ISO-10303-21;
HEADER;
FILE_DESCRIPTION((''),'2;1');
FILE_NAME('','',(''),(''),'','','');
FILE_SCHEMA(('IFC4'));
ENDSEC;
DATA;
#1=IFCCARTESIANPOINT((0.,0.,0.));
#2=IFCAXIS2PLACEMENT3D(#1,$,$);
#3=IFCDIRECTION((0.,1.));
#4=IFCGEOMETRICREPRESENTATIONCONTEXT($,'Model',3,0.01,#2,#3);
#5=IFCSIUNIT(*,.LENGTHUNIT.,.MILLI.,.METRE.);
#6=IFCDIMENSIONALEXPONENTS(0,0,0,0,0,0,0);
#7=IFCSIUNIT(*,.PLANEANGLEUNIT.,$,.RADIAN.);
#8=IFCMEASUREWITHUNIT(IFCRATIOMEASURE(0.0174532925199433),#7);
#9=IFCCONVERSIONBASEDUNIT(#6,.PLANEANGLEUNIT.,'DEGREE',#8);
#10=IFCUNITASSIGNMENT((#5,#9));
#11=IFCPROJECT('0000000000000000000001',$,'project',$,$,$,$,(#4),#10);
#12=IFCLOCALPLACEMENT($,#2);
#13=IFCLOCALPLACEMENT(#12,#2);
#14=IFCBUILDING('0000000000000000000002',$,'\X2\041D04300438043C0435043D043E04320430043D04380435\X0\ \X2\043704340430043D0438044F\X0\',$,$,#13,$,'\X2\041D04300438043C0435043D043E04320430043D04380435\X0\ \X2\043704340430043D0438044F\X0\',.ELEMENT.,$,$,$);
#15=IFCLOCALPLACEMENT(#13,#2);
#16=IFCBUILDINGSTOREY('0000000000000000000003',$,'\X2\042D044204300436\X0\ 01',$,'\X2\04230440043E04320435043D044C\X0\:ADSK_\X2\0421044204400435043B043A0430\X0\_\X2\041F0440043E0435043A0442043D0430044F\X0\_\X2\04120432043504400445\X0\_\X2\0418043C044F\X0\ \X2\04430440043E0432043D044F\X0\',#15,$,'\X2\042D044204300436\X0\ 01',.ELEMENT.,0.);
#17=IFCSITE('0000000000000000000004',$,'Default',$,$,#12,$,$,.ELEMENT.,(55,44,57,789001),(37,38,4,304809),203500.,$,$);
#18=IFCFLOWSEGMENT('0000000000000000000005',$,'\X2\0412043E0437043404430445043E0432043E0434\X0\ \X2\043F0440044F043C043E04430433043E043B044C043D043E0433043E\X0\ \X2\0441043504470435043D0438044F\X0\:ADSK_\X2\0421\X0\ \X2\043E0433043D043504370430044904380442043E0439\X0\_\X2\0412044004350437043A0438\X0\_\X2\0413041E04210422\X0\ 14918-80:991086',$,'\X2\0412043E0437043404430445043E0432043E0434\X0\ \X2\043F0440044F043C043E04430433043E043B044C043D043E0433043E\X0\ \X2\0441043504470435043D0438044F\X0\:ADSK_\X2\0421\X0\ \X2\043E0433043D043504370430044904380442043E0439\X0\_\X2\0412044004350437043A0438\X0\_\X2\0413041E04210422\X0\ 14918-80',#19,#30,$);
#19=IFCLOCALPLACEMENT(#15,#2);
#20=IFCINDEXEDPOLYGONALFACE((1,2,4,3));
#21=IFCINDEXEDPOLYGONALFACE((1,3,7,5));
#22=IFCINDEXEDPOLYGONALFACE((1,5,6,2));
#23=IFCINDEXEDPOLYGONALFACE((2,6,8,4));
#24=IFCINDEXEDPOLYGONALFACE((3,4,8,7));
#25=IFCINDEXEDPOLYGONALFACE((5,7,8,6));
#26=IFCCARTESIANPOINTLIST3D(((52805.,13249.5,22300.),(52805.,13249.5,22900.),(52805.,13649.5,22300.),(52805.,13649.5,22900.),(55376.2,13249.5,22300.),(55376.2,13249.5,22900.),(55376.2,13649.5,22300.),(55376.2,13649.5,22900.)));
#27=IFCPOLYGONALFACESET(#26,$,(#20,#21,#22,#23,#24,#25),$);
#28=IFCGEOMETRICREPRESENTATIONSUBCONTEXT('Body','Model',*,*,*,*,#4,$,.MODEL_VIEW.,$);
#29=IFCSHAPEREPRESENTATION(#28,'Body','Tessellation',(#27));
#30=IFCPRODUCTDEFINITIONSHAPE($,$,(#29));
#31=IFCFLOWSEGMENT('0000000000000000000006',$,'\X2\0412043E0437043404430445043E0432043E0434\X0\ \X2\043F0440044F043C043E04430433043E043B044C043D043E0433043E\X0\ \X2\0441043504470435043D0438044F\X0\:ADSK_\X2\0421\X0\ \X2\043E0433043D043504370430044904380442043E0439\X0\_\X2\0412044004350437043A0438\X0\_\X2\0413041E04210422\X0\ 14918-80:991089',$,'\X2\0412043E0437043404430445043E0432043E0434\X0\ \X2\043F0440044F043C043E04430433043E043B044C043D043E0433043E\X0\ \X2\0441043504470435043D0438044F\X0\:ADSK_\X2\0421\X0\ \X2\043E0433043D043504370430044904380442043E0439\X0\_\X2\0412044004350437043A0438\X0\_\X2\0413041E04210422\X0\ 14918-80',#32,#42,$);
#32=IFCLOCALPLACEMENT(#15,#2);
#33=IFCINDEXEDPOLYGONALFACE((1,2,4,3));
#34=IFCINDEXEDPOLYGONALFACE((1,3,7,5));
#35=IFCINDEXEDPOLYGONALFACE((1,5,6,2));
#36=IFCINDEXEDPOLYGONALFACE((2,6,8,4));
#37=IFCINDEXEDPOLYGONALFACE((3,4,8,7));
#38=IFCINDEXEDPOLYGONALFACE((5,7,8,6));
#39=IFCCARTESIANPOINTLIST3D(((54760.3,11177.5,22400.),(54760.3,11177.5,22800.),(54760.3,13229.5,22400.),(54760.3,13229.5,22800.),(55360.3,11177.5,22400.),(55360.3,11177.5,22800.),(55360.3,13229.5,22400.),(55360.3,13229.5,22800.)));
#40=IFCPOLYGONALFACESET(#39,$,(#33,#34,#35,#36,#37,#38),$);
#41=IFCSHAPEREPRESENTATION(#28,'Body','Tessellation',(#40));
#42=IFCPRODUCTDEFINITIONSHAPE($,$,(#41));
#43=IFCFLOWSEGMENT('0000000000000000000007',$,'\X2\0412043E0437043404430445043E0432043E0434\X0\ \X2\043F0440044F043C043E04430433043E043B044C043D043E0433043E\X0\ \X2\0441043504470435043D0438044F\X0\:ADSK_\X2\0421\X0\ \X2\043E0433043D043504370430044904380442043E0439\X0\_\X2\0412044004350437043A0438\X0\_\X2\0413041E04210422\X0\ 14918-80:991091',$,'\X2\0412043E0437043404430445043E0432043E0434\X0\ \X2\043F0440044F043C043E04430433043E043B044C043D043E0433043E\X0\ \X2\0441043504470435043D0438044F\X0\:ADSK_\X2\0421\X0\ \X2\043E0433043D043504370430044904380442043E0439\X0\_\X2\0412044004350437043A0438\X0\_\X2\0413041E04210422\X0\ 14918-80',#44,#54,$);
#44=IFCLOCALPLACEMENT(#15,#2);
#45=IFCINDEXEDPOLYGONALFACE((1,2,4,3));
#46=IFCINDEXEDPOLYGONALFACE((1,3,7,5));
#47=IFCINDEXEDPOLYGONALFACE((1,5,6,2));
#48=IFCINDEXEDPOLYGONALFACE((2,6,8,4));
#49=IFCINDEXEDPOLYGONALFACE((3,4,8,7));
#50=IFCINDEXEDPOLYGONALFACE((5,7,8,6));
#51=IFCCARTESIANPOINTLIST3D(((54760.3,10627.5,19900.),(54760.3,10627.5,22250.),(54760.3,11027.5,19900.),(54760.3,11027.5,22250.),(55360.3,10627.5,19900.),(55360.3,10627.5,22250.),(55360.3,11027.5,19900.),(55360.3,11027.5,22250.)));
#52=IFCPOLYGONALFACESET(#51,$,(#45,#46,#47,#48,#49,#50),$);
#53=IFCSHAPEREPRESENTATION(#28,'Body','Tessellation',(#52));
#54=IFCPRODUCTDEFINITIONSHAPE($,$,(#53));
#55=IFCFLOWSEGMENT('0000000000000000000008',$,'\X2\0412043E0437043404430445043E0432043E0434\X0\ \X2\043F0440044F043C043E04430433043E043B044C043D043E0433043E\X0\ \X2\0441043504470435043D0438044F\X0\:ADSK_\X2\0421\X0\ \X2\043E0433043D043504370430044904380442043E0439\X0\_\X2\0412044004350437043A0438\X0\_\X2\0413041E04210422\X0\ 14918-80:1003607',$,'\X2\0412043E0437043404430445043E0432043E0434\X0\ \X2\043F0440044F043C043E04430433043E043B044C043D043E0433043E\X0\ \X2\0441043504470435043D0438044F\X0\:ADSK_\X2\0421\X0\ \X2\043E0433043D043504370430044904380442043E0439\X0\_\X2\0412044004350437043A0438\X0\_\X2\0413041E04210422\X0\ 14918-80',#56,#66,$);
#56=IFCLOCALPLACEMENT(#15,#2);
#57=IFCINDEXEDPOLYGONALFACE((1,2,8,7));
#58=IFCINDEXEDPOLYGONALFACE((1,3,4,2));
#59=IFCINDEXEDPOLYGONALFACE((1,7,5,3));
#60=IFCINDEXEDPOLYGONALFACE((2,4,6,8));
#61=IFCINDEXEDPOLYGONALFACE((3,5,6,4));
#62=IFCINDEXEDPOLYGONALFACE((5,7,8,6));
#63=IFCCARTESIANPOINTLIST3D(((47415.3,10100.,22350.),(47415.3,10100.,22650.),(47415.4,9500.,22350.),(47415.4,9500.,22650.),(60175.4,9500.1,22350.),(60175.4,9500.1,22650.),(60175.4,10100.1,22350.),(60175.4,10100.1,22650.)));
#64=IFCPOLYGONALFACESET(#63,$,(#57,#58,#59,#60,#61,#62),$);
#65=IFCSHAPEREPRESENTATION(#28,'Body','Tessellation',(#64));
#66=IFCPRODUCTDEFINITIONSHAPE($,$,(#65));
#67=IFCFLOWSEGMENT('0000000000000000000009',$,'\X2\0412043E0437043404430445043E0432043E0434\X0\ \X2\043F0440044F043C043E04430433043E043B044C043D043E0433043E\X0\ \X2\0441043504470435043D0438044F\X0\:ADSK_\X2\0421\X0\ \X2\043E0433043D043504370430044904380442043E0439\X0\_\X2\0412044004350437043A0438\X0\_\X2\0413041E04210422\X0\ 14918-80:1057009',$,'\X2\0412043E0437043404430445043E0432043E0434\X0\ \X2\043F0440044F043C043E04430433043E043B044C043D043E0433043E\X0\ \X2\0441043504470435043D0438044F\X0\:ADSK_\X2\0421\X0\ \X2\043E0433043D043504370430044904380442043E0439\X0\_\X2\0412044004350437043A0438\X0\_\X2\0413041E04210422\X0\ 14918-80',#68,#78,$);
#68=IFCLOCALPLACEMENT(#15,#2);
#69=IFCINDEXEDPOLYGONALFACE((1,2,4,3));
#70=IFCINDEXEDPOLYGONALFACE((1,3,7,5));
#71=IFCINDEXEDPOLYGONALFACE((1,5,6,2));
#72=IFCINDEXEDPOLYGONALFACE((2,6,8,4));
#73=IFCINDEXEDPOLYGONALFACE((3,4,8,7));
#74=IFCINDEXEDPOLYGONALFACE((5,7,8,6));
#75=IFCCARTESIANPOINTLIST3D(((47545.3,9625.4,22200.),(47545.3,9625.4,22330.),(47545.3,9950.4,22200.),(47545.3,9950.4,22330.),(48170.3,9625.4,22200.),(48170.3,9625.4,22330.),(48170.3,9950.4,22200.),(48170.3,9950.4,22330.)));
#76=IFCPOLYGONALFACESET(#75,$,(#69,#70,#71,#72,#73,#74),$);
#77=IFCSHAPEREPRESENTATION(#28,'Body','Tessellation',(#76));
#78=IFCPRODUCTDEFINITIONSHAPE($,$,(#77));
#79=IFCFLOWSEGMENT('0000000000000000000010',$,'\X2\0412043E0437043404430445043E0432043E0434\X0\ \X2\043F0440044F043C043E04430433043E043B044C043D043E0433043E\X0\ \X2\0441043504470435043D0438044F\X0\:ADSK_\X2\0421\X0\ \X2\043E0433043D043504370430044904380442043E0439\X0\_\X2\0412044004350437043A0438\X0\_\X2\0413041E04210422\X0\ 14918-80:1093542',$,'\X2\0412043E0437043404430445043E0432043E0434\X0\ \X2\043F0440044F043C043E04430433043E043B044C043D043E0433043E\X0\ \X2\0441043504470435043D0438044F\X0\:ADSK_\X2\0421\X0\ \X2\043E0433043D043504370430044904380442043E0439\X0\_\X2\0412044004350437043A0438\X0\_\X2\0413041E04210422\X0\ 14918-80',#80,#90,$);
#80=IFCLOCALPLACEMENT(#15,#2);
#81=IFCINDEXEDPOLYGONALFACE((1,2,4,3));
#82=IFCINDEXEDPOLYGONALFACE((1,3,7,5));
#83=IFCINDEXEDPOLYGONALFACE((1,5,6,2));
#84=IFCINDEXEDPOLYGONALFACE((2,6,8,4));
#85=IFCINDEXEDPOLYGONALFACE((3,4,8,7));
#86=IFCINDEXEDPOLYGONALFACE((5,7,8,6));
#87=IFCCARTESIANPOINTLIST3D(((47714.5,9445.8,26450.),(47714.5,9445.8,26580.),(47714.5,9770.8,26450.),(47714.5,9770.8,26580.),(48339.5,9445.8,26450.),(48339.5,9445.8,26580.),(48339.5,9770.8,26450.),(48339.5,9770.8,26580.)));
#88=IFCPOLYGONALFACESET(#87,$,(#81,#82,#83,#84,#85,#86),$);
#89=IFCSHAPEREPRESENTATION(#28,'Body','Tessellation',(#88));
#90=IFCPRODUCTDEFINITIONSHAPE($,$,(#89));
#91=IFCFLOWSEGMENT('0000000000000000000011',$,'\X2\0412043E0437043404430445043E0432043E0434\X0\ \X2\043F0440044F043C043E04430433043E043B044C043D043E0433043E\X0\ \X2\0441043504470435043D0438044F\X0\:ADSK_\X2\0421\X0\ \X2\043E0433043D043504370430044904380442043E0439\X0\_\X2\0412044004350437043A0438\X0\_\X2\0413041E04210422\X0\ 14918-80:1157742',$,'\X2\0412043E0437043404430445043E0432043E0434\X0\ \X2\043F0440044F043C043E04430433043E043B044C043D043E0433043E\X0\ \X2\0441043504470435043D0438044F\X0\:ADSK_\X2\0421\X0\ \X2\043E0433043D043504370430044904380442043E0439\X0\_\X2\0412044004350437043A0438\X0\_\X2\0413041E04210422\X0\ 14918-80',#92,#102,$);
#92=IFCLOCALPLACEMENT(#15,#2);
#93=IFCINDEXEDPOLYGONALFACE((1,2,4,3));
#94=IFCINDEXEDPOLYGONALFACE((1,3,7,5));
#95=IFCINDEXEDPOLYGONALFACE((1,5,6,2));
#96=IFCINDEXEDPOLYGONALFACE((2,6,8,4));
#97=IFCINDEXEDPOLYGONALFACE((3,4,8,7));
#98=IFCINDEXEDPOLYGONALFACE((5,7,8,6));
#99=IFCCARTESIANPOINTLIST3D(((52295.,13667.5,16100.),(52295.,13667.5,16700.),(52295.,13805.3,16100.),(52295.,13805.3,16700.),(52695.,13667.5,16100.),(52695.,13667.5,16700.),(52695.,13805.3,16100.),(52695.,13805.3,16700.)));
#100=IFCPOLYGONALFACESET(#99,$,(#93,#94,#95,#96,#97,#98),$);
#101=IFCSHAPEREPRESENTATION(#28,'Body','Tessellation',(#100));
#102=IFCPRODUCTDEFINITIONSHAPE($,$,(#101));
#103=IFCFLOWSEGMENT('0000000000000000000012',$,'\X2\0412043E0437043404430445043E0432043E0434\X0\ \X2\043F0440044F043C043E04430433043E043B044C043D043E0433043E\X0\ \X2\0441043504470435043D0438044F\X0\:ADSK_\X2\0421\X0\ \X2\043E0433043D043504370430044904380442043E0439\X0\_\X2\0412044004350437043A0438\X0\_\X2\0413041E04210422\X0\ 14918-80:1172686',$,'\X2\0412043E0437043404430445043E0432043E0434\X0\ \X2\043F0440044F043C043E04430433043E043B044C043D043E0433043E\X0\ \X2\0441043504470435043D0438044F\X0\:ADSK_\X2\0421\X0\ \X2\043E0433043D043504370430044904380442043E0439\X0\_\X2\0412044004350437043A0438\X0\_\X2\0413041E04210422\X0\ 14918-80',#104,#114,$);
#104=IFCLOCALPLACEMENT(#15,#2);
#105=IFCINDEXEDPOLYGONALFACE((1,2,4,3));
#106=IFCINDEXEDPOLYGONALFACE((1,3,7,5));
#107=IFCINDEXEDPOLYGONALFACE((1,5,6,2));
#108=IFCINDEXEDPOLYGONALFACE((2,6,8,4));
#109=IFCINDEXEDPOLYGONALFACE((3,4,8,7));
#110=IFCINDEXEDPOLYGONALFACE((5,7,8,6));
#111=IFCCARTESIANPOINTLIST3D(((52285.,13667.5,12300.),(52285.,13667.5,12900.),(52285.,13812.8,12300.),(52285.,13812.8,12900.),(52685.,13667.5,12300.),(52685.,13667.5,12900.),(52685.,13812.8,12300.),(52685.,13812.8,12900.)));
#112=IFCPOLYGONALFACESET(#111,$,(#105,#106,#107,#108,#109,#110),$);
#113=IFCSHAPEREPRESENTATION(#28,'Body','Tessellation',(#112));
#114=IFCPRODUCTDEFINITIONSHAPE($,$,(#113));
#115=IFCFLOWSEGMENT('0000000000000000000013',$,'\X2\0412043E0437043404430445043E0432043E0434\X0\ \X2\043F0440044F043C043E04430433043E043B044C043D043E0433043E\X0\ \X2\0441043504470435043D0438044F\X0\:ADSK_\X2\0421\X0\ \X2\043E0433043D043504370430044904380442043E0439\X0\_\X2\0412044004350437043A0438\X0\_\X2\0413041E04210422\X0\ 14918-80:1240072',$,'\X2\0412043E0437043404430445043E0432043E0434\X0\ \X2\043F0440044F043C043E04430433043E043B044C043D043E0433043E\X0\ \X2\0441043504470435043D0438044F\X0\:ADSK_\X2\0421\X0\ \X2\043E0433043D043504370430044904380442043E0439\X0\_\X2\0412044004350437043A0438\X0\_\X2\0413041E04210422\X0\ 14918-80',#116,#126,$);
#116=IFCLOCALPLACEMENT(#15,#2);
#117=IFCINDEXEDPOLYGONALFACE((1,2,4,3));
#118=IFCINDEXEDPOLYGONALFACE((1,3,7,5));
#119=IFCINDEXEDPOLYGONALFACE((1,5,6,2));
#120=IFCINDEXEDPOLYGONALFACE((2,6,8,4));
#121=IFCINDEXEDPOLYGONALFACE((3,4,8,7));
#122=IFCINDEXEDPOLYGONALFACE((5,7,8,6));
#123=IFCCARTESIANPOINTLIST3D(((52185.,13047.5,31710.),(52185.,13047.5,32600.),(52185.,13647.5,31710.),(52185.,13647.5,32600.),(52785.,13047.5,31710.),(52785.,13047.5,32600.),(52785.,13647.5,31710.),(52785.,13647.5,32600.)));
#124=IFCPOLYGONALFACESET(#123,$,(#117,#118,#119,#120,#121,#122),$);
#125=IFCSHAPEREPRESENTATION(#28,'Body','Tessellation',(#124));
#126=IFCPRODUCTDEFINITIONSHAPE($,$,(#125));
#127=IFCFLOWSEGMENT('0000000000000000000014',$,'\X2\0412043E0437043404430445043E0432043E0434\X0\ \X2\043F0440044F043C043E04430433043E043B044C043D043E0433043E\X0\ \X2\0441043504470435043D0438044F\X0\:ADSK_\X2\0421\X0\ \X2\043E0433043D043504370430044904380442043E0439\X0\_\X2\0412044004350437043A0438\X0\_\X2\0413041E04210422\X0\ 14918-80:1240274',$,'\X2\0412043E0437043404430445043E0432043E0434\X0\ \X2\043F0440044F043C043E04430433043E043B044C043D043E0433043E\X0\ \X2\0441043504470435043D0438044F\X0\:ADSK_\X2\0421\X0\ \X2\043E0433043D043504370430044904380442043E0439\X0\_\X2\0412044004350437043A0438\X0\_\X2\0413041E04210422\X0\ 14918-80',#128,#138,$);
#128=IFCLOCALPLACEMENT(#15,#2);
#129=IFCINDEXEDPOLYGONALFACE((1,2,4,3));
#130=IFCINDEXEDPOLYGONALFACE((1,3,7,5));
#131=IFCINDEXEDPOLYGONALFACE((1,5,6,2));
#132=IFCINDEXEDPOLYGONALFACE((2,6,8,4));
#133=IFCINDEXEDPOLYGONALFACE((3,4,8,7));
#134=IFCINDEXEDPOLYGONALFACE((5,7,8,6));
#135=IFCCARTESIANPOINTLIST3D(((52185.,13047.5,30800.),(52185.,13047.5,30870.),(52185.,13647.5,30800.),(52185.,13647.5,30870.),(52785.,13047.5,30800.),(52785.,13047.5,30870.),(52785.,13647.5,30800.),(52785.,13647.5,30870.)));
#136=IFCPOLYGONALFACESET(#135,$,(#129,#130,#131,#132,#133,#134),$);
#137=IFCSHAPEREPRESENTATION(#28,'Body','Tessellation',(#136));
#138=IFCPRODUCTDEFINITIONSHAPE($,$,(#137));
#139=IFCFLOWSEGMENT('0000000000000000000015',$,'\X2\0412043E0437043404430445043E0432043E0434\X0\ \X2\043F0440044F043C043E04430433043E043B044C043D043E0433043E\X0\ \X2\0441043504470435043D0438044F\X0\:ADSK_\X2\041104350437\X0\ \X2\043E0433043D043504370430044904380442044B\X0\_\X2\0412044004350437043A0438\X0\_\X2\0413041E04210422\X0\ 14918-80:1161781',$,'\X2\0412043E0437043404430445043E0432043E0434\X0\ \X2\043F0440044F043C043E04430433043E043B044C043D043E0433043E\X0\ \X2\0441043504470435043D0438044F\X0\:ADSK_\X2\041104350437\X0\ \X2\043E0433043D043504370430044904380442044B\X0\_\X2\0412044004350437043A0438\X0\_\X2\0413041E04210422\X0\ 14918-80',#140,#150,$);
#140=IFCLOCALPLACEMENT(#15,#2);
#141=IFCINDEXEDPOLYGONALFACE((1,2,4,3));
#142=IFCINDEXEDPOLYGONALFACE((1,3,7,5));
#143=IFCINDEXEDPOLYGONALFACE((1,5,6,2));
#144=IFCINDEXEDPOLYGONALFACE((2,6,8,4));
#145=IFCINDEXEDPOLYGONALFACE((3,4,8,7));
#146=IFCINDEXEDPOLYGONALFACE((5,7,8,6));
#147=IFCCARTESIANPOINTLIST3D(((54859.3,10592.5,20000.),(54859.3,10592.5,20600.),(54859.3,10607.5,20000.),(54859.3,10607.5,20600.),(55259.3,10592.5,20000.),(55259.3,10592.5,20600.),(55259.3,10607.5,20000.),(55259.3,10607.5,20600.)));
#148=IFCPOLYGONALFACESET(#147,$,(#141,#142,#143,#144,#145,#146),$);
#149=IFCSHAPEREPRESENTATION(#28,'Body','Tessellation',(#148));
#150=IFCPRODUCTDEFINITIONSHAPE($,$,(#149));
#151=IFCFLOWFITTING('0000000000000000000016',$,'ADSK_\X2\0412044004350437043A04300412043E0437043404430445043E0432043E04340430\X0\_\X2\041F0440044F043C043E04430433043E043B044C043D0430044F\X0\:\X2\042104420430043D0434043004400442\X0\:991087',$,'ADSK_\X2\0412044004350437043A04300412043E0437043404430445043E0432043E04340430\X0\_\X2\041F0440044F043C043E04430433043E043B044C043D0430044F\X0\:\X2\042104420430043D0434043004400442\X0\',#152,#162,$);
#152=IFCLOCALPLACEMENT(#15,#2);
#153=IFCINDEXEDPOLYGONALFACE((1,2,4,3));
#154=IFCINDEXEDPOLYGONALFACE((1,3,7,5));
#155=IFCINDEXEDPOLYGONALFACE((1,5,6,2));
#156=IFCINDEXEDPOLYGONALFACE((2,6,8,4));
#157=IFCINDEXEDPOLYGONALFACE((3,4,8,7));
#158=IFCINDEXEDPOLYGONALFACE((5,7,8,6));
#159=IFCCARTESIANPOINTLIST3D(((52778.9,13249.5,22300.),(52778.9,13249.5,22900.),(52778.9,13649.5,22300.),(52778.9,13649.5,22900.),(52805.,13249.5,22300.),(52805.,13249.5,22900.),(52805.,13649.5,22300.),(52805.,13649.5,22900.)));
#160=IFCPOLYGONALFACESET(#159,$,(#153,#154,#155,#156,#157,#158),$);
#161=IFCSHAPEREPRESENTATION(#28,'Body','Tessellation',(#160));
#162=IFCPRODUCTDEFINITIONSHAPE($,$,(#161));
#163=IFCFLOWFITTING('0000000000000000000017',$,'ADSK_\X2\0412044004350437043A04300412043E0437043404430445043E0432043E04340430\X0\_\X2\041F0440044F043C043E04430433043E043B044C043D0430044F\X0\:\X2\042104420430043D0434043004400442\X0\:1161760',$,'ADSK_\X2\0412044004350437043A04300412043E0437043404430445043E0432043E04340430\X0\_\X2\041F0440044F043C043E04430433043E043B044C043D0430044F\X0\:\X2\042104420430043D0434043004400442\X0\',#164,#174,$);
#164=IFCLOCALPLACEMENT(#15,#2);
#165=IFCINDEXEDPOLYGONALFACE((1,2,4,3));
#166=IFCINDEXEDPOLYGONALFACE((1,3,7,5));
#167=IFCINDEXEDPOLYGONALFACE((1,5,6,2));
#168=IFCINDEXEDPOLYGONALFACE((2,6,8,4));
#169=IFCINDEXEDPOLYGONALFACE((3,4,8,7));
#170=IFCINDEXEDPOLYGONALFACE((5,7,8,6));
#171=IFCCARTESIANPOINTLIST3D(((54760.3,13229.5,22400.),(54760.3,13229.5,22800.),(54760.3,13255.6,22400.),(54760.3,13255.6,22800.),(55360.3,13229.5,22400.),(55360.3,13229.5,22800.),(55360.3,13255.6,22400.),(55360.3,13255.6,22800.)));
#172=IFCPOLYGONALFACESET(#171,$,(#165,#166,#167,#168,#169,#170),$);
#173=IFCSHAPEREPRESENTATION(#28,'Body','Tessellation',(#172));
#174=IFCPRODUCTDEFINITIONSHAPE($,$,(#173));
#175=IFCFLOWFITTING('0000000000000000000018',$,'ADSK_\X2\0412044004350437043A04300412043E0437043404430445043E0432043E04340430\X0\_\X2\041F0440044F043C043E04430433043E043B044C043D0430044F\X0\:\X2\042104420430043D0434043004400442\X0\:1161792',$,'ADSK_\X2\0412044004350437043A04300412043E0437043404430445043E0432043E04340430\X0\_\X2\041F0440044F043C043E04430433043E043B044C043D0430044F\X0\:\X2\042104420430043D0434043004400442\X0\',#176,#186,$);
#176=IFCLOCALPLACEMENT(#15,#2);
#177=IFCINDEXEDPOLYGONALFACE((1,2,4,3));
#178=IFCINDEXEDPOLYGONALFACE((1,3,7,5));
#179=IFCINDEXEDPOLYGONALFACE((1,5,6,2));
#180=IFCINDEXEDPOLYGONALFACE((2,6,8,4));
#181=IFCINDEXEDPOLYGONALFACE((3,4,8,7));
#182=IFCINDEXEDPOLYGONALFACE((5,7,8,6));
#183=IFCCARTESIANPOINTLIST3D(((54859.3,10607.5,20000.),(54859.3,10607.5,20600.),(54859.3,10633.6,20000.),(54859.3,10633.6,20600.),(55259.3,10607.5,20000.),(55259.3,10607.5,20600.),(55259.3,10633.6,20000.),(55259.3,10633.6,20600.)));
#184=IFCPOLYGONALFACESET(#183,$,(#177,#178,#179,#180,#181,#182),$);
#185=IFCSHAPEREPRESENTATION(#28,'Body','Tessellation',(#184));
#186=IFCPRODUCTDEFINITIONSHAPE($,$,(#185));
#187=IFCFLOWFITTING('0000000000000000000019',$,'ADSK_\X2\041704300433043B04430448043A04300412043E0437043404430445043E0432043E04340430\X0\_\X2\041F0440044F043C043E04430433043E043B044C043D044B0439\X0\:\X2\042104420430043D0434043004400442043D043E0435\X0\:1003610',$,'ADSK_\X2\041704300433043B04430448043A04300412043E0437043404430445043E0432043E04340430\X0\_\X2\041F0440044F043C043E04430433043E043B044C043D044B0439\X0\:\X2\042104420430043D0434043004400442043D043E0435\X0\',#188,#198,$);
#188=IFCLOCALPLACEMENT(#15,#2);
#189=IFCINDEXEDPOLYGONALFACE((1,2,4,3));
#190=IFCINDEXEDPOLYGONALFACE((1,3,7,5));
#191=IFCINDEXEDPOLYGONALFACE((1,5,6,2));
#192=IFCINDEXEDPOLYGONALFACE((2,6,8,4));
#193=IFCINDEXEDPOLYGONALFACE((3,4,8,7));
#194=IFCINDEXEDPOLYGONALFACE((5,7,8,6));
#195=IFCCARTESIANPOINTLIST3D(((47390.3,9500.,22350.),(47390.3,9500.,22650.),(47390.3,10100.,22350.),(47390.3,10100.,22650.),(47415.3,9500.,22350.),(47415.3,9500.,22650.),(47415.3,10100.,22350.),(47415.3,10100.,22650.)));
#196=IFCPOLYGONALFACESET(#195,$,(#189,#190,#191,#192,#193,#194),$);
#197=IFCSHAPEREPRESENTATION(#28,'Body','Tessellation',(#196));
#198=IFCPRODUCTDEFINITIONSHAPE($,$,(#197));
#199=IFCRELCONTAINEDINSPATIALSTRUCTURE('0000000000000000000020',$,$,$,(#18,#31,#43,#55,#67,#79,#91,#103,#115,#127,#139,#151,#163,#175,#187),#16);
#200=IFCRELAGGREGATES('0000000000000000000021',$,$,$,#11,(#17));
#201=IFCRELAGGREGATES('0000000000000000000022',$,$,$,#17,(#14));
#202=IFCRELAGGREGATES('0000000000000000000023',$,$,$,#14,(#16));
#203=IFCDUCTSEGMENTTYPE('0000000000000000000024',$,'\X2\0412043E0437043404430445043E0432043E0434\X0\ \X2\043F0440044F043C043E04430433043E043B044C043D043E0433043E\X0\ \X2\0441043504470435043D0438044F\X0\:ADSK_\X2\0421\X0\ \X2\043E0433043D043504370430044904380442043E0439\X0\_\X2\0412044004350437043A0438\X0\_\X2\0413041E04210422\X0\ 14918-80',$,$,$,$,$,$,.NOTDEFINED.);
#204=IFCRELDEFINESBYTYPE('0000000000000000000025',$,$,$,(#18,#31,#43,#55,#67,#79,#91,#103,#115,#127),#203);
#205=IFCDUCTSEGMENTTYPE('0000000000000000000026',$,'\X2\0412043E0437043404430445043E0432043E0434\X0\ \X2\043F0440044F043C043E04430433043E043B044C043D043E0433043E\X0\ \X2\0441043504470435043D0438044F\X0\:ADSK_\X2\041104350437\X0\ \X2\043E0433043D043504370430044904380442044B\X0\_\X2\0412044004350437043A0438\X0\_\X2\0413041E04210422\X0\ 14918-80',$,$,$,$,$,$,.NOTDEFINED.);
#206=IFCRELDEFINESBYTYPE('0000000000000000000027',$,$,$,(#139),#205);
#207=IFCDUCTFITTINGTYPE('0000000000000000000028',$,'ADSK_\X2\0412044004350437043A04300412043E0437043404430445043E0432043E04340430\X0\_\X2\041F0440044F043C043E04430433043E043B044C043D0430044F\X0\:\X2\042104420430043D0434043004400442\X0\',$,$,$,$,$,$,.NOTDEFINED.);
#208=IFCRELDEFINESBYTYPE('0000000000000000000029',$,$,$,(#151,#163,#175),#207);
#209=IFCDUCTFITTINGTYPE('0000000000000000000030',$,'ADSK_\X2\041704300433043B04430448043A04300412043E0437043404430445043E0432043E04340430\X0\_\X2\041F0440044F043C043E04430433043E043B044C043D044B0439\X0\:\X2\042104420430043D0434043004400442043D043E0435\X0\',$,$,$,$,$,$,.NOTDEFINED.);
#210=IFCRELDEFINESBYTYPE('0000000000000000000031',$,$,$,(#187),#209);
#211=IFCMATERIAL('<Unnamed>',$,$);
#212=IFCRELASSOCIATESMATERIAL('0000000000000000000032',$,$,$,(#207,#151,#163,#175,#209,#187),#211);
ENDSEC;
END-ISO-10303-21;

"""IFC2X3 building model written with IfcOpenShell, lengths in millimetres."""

from ifc_helpers import new_model, entity, si_unit, converted_unit, direction, frame, origin, origin_2d_with_axis, place, context, subcontext, project, spatial, rectangle, extrude, source, transform, mapped, material, type_object, type_shapes, element, save


model = new_model("IFC2X3")

# Units and contexts
model_context = context("Model", 3, precision=0.01, world=origin(), true_north=direction((0.0, 1.0)))
body_context = subcontext(model_context, "Body", "Model", "MODEL_VIEW")
ifc_project = project(units=[si_unit("LENGTHUNIT", "METRE", prefix="MILLI"), converted_unit("PLANEANGLEUNIT", "DEGREE", entity("IfcRatioMeasure", 0.0174532925199433), si_unit("PLANEANGLEUNIT", "RADIAN"), dimensions=[0, 0, 0, 0, 0, 0, 0])], contexts=[model_context])

# Site, building, storey
site_placement = place(None, origin())
site = spatial("IfcSite", under=ifc_project, at=site_placement, Name="Default", CompositionType="ELEMENT", RefLatitude=(55, 44, 57, 789001), RefLongitude=(37, 38, 4, 304809), RefElevation=203500.0)
building_placement = place(site_placement, origin())
building = spatial("IfcBuilding", under=site, at=building_placement, Name="Наименование здания", LongName="Наименование здания", CompositionType="ELEMENT")
storey_placement = place(building_placement, origin())
storey = spatial("IfcBuildingStorey", under=building, at=storey_placement, Name="Этаж 01", ObjectType="Уровень:ADSK_Стрелка_Проектная_Вверх_Имя уровня", LongName="Этаж 01", CompositionType="ELEMENT", Elevation=0.0)

# Flow segments
duct_segment_type_1 = type_object("IfcDuctSegmentType", Name="Воздуховод прямоугольного сечения:ADSK_С огнезащитой_Врезки_ГОСТ 14918-80", PredefinedType="NOTDEFINED")
flow_segment_1_placement = place(storey_placement, frame((52805.0, 13249.5, 22300.0)))
element("IfcFlowSegment", 1, at=flow_segment_1_placement, inside=storey, type_object=duct_segment_type_1, Name="Воздуховод прямоугольного сечения:ADSK_С огнезащитой_Врезки_ГОСТ 14918-80:991086", ObjectType="Воздуховод прямоугольного сечения:ADSK_С огнезащитой_Врезки_ГОСТ 14918-80", context=body_context, shape_type="SweptSolid", body=[
    extrude(rectangle(XDim=2571.2, YDim=400.0, at=origin_2d_with_axis()), frame((1285.6, 200.0, 0.0)), (0.0, 0.0, 1.0), 600.0),
])
flow_segment_2_placement = place(storey_placement, frame((54760.3, 11177.5, 22400.0)))
element("IfcFlowSegment", 2, at=flow_segment_2_placement, inside=storey, type_object=duct_segment_type_1, Name="Воздуховод прямоугольного сечения:ADSK_С огнезащитой_Врезки_ГОСТ 14918-80:991089", ObjectType="Воздуховод прямоугольного сечения:ADSK_С огнезащитой_Врезки_ГОСТ 14918-80", context=body_context, shape_type="SweptSolid", body=[
    extrude(rectangle(XDim=2052.0, YDim=600.0, at=origin_2d_with_axis()), frame((300.0, 1026.0, 0.0), z_axis=(0.0, 0.0, 1.0), x_axis=(0.0, -1.0, 0.0)), (0.0, 0.0, 1.0), 400.0),
])
flow_segment_3_placement = place(storey_placement, frame((54760.3, 10627.5, 19900.0)))
element("IfcFlowSegment", 3, at=flow_segment_3_placement, inside=storey, type_object=duct_segment_type_1, Name="Воздуховод прямоугольного сечения:ADSK_С огнезащитой_Врезки_ГОСТ 14918-80:991091", ObjectType="Воздуховод прямоугольного сечения:ADSK_С огнезащитой_Врезки_ГОСТ 14918-80", context=body_context, shape_type="SweptSolid", body=[
    extrude(rectangle(XDim=600.0, YDim=400.0, at=origin_2d_with_axis()), frame((300.0, 200.0, 0.0)), (0.0, 0.0, 1.0), 2350.0),
])
flow_segment_4_placement = place(storey_placement, frame((47415.3, 9500.0, 22350.0)))
element("IfcFlowSegment", 4, at=flow_segment_4_placement, inside=storey, type_object=duct_segment_type_1, Name="Воздуховод прямоугольного сечения:ADSK_С огнезащитой_Врезки_ГОСТ 14918-80:1003607", ObjectType="Воздуховод прямоугольного сечения:ADSK_С огнезащитой_Врезки_ГОСТ 14918-80", context=body_context, shape_type="SweptSolid", body=[
    extrude(rectangle(XDim=12760.1, YDim=600.0, at=origin_2d_with_axis()), frame((6380.0, 300.1, 0.0), z_axis=(0.0, 0.0, 1.0), x_axis=(-1.0, -0.000015, 0.0)), (0.0, 0.0, 1.0), 300.0),
])
flow_segment_5_placement = place(storey_placement, frame((47545.3, 9625.5, 22200.0)))
element("IfcFlowSegment", 5, at=flow_segment_5_placement, inside=storey, type_object=duct_segment_type_1, Name="Воздуховод прямоугольного сечения:ADSK_С огнезащитой_Врезки_ГОСТ 14918-80:1057009", ObjectType="Воздуховод прямоугольного сечения:ADSK_С огнезащитой_Врезки_ГОСТ 14918-80", context=body_context, shape_type="SweptSolid", body=[
    extrude(rectangle(XDim=325.0, YDim=625.0, at=origin_2d_with_axis()), frame((312.5, 162.5, 0.0), z_axis=(0.0, 0.0, 1.0), x_axis=(0.0, -1.0, 0.0)), (0.0, 0.0, 1.0), 130.0),
])
flow_segment_6_placement = place(storey_placement, frame((47714.5, 9445.8, 26450.0)))
element("IfcFlowSegment", 6, at=flow_segment_6_placement, inside=storey, type_object=duct_segment_type_1, Name="Воздуховод прямоугольного сечения:ADSK_С огнезащитой_Врезки_ГОСТ 14918-80:1093542", ObjectType="Воздуховод прямоугольного сечения:ADSK_С огнезащитой_Врезки_ГОСТ 14918-80", context=body_context, shape_type="SweptSolid", body=[
    extrude(rectangle(XDim=625.0, YDim=325.0, at=origin_2d_with_axis()), frame((312.5, 162.5, 0.0)), (0.0, 0.0, 1.0), 130.0),
])
flow_segment_7_placement = place(storey_placement, frame((52294.9, 13667.5, 16100.0)))
element("IfcFlowSegment", 7, at=flow_segment_7_placement, inside=storey, type_object=duct_segment_type_1, Name="Воздуховод прямоугольного сечения:ADSK_С огнезащитой_Врезки_ГОСТ 14918-80:1157742", ObjectType="Воздуховод прямоугольного сечения:ADSK_С огнезащитой_Врезки_ГОСТ 14918-80", context=body_context, shape_type="SweptSolid", body=[
    extrude(rectangle(XDim=137.8, YDim=400.0, at=origin_2d_with_axis()), frame((200.0, 68.9, 0.0), z_axis=(0.0, 0.0, 1.0), x_axis=(0.0, -1.0, 0.0)), (0.0, 0.0, 1.0), 600.0),
])
flow_segment_8_placement = place(storey_placement, frame((52285.0, 13667.5, 12300.0)))
element("IfcFlowSegment", 8, at=flow_segment_8_placement, inside=storey, type_object=duct_segment_type_1, Name="Воздуховод прямоугольного сечения:ADSK_С огнезащитой_Врезки_ГОСТ 14918-80:1172686", ObjectType="Воздуховод прямоугольного сечения:ADSK_С огнезащитой_Врезки_ГОСТ 14918-80", context=body_context, shape_type="SweptSolid", body=[
    extrude(rectangle(XDim=145.3, YDim=400.0, at=origin_2d_with_axis()), frame((200.0, 72.6, 0.0), z_axis=(0.0, 0.0, 1.0), x_axis=(0.0, 1.0, 0.0)), (0.0, 0.0, 1.0), 600.0),
])
flow_segment_9_placement = place(storey_placement, frame((52185.0, 13047.5, 31710.0)))
element("IfcFlowSegment", 9, at=flow_segment_9_placement, inside=storey, type_object=duct_segment_type_1, Name="Воздуховод прямоугольного сечения:ADSK_С огнезащитой_Врезки_ГОСТ 14918-80:1240072", ObjectType="Воздуховод прямоугольного сечения:ADSK_С огнезащитой_Врезки_ГОСТ 14918-80", context=body_context, shape_type="SweptSolid", body=[
    extrude(rectangle(XDim=600.0, YDim=600.0, at=origin_2d_with_axis()), frame((300.0, 300.0, 0.0), z_axis=(0.0, 0.0, 1.0), x_axis=(0.0, -1.0, 0.0)), (0.0, 0.0, 1.0), 890.0),
])
flow_segment_10_placement = place(storey_placement, frame((52185.0, 13047.5, 30800.0)))
element("IfcFlowSegment", 10, at=flow_segment_10_placement, inside=storey, type_object=duct_segment_type_1, Name="Воздуховод прямоугольного сечения:ADSK_С огнезащитой_Врезки_ГОСТ 14918-80:1240274", ObjectType="Воздуховод прямоугольного сечения:ADSK_С огнезащитой_Врезки_ГОСТ 14918-80", context=body_context, shape_type="SweptSolid", body=[
    extrude(rectangle(XDim=600.0, YDim=600.0, at=origin_2d_with_axis()), frame((300.0, 300.0, 0.0), z_axis=(0.0, 0.0, 1.0), x_axis=(0.0, 1.0, 0.0)), (0.0, 0.0, 1.0), 70.0),
])
duct_segment_type_2 = type_object("IfcDuctSegmentType", Name="Воздуховод прямоугольного сечения:ADSK_Без огнезащиты_Врезки_ГОСТ 14918-80", PredefinedType="NOTDEFINED")
flow_segment_11_placement = place(storey_placement, frame((54859.3, 10592.5, 20000.0)))
element("IfcFlowSegment", 11, at=flow_segment_11_placement, inside=storey, type_object=duct_segment_type_2, Name="Воздуховод прямоугольного сечения:ADSK_Без огнезащиты_Врезки_ГОСТ 14918-80:1161781", ObjectType="Воздуховод прямоугольного сечения:ADSK_Без огнезащиты_Врезки_ГОСТ 14918-80", context=body_context, shape_type="SweptSolid", body=[
    extrude(rectangle(XDim=15.0, YDim=400.0, at=origin_2d_with_axis()), frame((200.0, 7.5, 0.0), z_axis=(0.0, 0.0, 1.0), x_axis=(0.0, -1.0, 0.0)), (0.0, 0.0, 1.0), 600.0),
])

# Flow fittings
ifc_material_1 = material(Name="<Unnamed>")
duct_fitting_type_1 = type_object("IfcDuctFittingType", Name="ADSK_ВрезкаВоздуховода_Прямоугольная:Стандарт", PredefinedType="NOTDEFINED", material=ifc_material_1)
shared_shape_1 = source(origin(), body_context, "Body", "SweptSolid", [
    extrude(rectangle(XDim=26.1, YDim=600.0, at=origin_2d_with_axis()), frame((7.0, 0.0, -200.0)), (0.0, 0.0, 1.0), 400.0),
])
type_shapes(duct_fitting_type_1, [shared_shape_1])
for number, where, z_axis, x_axis, name in (
    (12, (52785.0, 13449.5, 22600.0), (0.0, -1.0, 0.0), (1.0, 0.0, 0.0), "ADSK_ВрезкаВоздуховода_Прямоугольная:Стандарт:991087"),
    (13, (55060.3, 13249.5, 22600.0), (0.0, 0.0, -1.0), (0.0, -1.0, 0.0), "ADSK_ВрезкаВоздуховода_Прямоугольная:Стандарт:1161760"),
    (14, (55059.3, 10627.5, 20300.0), (-1.0, 0.0, 0.0), (0.0, -1.0, 0.0), "ADSK_ВрезкаВоздуховода_Прямоугольная:Стандарт:1161792"),
):
    element("IfcFlowFitting", number, at=place(storey_placement, frame(where, z_axis=z_axis, x_axis=x_axis)), inside=storey, type_object=duct_fitting_type_1, material=ifc_material_1, Name=name, ObjectType="ADSK_ВрезкаВоздуховода_Прямоугольная:Стандарт", context=body_context, shape_type="MappedRepresentation", body=[
        mapped(shared_shape_1, transform((0.0, 0.0, 0.0), scale=1.0)),
    ])
duct_fitting_type_2 = type_object("IfcDuctFittingType", Name="ADSK_ЗаглушкаВоздуховода_Прямоугольный:Стандартное", PredefinedType="NOTDEFINED", material=ifc_material_1)
shared_shape_2 = source(origin(), body_context, "Body", "SweptSolid", [
    extrude(rectangle(XDim=25.0, YDim=600.0, at=origin_2d_with_axis()), frame((12.5, 0.0, -150.0)), (0.0, 0.0, 1.0), 300.0),
])
type_shapes(duct_fitting_type_2, [shared_shape_2])
flow_fitting_1_placement = place(storey_placement, frame((47415.3, 9800.0, 22500.0), z_axis=(0.0, 0.0, 1.0), x_axis=(-1.0, 0.0, 0.0)))
element("IfcFlowFitting", 15, at=flow_fitting_1_placement, inside=storey, type_object=duct_fitting_type_2, material=ifc_material_1, Name="ADSK_ЗаглушкаВоздуховода_Прямоугольный:Стандартное:1003610", ObjectType="ADSK_ЗаглушкаВоздуховода_Прямоугольный:Стандартное", context=body_context, shape_type="MappedRepresentation", body=[
    mapped(shared_shape_2, transform((0.0, 0.0, 0.0), scale=1.0)),
])

save(model, "model.ifc")
